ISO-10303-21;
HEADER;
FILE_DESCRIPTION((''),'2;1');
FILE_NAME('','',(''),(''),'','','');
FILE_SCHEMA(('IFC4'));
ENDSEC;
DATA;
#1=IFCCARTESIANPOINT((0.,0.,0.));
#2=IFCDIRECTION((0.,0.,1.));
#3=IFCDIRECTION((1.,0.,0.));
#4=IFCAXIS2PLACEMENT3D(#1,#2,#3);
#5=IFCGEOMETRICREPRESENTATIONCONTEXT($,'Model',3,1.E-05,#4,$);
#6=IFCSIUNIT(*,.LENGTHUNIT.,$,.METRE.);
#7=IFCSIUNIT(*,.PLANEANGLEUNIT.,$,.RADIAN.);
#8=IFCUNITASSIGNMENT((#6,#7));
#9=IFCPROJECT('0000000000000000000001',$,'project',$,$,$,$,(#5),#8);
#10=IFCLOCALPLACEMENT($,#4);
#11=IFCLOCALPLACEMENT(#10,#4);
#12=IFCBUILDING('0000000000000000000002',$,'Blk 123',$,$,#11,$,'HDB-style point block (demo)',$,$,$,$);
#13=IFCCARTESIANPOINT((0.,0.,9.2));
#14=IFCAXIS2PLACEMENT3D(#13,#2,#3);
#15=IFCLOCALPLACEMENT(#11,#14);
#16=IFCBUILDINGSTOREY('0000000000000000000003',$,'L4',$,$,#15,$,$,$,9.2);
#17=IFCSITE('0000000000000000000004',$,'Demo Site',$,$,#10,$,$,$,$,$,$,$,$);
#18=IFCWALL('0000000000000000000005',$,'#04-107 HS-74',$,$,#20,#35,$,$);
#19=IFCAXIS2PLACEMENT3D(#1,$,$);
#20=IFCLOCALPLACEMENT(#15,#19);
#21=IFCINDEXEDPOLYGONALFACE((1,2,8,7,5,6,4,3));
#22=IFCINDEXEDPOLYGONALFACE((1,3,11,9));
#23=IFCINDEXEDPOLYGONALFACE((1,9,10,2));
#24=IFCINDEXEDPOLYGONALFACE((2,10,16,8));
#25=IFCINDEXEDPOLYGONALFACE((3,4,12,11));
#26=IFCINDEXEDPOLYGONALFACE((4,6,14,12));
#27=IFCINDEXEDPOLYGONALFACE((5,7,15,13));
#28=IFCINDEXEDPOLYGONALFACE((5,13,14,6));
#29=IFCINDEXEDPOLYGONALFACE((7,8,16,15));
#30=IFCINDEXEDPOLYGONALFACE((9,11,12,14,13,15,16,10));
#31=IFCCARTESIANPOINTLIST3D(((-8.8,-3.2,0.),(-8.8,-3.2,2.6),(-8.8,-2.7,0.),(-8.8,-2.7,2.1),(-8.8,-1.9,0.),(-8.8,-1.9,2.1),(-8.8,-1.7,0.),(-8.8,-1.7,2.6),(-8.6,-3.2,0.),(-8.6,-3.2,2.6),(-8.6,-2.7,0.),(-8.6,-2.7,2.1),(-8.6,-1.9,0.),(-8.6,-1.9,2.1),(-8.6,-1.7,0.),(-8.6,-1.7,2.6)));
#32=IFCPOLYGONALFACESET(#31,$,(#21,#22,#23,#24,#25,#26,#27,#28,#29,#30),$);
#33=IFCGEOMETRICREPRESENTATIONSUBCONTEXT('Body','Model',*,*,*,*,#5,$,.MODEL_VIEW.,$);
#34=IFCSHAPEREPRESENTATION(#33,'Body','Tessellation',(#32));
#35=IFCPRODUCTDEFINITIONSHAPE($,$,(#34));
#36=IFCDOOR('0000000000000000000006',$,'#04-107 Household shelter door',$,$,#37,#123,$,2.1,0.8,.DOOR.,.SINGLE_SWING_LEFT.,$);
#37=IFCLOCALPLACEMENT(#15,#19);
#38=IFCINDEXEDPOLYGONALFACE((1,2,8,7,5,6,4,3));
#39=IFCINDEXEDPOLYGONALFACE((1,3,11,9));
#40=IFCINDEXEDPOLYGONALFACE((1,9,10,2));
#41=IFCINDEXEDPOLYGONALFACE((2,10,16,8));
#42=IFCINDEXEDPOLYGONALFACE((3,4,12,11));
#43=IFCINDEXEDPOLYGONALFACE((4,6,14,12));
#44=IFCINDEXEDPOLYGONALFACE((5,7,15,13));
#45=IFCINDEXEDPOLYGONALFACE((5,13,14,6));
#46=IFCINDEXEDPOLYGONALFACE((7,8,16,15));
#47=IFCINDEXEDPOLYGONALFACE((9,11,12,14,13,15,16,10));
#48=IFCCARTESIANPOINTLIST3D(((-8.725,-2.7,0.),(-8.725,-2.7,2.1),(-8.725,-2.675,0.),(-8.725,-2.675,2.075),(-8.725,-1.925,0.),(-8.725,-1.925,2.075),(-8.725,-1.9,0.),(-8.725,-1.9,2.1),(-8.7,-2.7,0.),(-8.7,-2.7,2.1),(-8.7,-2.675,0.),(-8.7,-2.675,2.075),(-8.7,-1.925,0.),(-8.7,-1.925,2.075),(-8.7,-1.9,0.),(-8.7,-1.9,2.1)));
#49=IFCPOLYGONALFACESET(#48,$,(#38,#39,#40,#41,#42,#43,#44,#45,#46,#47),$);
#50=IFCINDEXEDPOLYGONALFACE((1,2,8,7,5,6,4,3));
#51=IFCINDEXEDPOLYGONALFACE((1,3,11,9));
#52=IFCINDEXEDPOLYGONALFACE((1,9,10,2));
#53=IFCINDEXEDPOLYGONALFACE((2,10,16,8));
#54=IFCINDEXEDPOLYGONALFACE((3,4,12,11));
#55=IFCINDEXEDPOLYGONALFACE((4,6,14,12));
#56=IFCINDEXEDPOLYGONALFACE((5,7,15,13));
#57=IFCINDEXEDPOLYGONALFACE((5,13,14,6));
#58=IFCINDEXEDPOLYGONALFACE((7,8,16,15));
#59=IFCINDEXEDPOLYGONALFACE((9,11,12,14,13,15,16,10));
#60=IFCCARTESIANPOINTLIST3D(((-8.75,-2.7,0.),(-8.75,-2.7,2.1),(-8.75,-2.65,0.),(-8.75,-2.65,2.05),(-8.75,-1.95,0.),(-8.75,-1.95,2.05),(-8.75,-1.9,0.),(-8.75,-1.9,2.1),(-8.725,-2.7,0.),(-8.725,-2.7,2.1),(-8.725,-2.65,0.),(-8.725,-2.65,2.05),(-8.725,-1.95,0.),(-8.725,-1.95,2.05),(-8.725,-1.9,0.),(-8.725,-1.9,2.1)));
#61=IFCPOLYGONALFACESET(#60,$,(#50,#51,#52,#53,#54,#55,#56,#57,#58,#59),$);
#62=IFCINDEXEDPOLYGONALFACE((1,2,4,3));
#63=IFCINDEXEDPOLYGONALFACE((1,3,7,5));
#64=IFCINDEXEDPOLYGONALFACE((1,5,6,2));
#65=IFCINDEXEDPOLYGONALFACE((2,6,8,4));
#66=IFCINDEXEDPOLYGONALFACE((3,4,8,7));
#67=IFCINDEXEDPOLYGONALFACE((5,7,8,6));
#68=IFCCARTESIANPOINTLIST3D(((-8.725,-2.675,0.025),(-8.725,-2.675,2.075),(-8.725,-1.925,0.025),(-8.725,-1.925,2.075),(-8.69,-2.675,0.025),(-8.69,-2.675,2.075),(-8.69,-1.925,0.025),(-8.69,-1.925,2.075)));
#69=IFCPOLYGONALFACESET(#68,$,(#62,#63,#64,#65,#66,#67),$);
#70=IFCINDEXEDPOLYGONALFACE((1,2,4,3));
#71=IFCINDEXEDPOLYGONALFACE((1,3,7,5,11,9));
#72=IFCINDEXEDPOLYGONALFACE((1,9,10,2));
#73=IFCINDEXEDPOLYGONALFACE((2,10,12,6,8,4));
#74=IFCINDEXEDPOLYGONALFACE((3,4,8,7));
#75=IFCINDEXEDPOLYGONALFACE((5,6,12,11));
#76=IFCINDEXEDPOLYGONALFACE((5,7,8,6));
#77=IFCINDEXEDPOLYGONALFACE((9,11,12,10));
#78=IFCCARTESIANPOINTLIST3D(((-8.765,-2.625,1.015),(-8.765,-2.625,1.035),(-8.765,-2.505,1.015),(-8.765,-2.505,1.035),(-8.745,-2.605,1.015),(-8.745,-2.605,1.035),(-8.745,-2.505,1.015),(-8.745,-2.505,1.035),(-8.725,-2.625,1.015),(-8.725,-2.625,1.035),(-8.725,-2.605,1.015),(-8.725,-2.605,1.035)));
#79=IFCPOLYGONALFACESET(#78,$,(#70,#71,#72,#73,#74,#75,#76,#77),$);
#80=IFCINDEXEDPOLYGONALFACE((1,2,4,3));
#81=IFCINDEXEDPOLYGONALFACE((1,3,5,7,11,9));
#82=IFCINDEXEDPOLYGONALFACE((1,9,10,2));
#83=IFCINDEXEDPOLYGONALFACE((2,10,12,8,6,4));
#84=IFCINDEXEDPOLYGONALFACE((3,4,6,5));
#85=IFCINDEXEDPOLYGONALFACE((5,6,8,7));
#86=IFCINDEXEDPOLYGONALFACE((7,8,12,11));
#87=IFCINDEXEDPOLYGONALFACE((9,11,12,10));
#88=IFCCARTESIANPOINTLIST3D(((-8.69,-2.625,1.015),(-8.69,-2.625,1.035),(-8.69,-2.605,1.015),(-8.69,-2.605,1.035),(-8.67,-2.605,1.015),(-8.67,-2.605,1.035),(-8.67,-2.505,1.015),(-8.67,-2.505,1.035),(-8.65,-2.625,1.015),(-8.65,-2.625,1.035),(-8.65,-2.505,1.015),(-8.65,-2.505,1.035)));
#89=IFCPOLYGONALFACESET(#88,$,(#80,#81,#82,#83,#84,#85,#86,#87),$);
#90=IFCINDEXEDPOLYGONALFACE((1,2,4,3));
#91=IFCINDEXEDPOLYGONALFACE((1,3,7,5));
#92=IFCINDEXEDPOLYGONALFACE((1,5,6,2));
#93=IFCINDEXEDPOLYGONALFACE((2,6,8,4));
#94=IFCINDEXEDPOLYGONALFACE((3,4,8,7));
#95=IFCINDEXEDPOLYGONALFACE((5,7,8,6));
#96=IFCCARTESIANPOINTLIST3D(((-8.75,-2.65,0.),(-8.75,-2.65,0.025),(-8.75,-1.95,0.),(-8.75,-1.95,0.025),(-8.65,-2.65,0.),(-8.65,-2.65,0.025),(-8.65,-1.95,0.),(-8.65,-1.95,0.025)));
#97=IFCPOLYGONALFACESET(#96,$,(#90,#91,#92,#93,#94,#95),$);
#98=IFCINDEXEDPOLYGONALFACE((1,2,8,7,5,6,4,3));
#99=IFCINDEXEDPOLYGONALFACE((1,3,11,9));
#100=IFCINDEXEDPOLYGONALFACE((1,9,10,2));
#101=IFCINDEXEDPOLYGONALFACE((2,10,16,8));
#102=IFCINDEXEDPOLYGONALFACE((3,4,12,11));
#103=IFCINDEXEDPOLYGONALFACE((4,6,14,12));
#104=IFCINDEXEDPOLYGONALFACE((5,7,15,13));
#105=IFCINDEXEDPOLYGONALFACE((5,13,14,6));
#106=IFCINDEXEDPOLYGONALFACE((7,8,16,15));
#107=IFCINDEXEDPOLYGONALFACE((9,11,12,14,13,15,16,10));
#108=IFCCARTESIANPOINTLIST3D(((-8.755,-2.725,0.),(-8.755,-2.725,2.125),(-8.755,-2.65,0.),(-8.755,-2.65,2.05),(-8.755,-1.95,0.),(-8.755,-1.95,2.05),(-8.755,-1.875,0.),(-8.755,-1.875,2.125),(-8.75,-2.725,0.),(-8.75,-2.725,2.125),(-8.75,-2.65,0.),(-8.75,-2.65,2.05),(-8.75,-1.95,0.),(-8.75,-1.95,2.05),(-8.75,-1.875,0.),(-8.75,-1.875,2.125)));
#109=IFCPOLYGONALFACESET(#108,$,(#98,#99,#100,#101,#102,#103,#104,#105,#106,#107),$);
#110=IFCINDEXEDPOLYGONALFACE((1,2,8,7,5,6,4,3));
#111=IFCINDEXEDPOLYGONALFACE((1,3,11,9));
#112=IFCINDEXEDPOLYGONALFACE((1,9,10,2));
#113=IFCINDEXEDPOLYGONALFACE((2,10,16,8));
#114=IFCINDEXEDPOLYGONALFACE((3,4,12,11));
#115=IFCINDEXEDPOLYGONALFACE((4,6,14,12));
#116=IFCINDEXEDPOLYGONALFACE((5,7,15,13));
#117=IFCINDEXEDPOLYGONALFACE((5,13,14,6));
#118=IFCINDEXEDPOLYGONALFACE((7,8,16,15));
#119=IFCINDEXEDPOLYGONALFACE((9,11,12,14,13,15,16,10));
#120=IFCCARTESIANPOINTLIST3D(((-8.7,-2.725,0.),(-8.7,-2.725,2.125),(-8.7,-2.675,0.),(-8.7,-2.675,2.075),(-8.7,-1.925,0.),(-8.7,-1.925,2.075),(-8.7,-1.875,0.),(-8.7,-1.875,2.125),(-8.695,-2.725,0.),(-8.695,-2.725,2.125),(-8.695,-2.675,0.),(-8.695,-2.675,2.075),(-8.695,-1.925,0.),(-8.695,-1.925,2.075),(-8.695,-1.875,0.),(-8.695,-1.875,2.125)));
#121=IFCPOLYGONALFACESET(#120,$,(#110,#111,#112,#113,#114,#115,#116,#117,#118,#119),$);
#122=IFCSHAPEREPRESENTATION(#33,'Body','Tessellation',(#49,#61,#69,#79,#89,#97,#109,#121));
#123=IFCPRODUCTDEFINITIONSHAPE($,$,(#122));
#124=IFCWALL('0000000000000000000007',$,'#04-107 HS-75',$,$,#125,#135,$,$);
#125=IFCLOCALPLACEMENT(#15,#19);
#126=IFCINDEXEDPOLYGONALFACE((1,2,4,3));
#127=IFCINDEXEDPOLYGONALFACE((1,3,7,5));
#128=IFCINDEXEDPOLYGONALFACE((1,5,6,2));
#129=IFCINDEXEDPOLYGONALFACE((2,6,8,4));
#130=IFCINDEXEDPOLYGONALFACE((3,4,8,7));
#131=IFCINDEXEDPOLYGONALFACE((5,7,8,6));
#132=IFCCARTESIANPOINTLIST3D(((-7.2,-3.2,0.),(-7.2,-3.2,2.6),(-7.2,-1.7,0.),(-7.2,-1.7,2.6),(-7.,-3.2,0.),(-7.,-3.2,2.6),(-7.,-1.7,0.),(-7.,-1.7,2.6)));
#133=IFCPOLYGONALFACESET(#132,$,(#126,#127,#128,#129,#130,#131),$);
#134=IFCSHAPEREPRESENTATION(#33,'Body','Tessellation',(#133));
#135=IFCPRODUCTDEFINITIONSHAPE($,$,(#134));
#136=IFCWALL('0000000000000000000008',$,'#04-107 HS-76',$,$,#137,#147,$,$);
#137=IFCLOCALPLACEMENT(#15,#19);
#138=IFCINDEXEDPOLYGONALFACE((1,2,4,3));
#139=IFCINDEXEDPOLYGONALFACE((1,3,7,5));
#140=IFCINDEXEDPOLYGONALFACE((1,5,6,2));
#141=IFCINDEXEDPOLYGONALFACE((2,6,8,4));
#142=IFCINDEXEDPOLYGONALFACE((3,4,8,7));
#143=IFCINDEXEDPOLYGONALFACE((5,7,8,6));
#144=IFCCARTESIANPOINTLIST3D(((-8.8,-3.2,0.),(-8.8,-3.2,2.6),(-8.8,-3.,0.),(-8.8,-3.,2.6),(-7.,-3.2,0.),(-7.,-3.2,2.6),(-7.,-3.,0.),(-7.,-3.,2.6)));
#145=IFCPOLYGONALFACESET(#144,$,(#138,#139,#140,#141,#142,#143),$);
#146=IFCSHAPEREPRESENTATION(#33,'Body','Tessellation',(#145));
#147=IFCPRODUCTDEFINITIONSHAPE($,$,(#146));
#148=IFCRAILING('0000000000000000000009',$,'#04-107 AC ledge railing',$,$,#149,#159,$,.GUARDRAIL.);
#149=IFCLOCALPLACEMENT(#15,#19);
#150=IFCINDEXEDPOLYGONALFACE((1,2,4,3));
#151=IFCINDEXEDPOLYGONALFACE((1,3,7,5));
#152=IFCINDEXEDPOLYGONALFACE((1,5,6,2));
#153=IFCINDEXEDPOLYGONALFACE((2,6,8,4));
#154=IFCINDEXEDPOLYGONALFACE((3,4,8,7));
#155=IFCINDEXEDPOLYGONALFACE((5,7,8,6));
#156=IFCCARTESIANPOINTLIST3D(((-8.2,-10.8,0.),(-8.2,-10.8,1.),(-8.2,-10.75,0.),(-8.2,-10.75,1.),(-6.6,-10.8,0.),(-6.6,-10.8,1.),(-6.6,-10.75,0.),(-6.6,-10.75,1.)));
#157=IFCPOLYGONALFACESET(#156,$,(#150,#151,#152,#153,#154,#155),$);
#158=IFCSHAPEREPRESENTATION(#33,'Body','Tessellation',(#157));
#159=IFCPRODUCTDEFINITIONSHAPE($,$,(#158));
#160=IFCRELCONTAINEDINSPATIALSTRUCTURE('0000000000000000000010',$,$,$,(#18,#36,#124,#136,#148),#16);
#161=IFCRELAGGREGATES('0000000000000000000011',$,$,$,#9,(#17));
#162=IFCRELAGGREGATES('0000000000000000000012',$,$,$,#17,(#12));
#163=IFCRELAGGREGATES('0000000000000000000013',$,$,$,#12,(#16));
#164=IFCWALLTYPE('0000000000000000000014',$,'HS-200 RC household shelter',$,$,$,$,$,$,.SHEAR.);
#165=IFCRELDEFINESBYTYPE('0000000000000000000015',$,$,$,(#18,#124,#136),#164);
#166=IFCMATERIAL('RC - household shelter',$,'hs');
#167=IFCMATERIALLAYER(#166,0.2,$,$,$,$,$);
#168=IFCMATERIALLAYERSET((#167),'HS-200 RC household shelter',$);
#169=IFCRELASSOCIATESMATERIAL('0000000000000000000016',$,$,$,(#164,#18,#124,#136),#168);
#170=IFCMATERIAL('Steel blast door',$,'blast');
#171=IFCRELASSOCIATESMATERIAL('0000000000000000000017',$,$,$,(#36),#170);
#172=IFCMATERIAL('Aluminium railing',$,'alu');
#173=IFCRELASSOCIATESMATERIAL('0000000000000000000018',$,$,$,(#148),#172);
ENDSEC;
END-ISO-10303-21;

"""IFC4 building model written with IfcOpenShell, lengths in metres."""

from ifc_helpers import new_model, si_unit, frame, origin, origin_with_axes, place, context, subcontext, project, spatial, polyline, line, indexed_curve, outline, extrude, material, layer, layer_set, layer_usage, type_object, element, fill, save


model = new_model("IFC4")

# Units and contexts
model_context = context("Model", 3, precision=1e-05, world=origin_with_axes())
body_context = subcontext(model_context, "Body", "Model", "MODEL_VIEW")
ifc_project = project(units=[si_unit("LENGTHUNIT", "METRE"), si_unit("PLANEANGLEUNIT", "RADIAN")], contexts=[model_context])

# Site, building, storey
site_placement = place(None, origin_with_axes())
site = spatial("IfcSite", under=ifc_project, at=site_placement, Name="Demo Site")
building_placement = place(site_placement, origin_with_axes())
building = spatial("IfcBuilding", under=site, at=building_placement, Name="Blk 123", LongName="HDB-style point block (demo)")
storey_placement = place(building_placement, frame((0.0, 0.0, 9.2), z_axis=(0.0, 0.0, 1.0), x_axis=(1.0, 0.0, 0.0)))
storey = spatial("IfcBuildingStorey", under=building, at=storey_placement, Name="L4", Elevation=9.2)

# Wall, opening, door
ifc_material_1 = material(Name="RC - household shelter", Category="hs")
ifc_layer_1 = layer(ifc_material_1, 0.2)
ifc_layer_set_1 = layer_set([ifc_layer_1], Name="HS-200 RC household shelter")
ifc_layer_usage_1 = layer_usage(ifc_layer_set_1, "AXIS2", "POSITIVE", -0.1)
wall_type_1 = type_object("IfcWallType", Name="HS-200 RC household shelter", PredefinedType="SHEAR", material=ifc_layer_set_1)
wall_1_placement = place(storey_placement, frame((-8.7, -1.7, 0.0), z_axis=(0.0, 0.0, 1.0), x_axis=(0.0, -1.0, 0.0)))
wall_1 = element("IfcWall", 1, at=wall_1_placement, inside=storey, type_object=wall_type_1, material=ifc_layer_usage_1, Name="#04-107 HS-74", context=body_context, shape_type="SweptSolid", body=[
    extrude(outline(indexed_curve([(0.0, 0.0), (0.0, 0.2), (1.5, 0.2), (1.5, 0.0), (0.0, 0.0)], self_intersect=False)), frame((0.0, -0.1, 0.0), z_axis=(0.0, 0.0, 1.0), x_axis=(1.0, 0.0, 0.0)), (0.0, 0.0, 1.0), 2.6),
])
opening_1_placement = place(wall_1_placement, frame((0.2, -0.2, 0.0), z_axis=(0.0, 0.0, 1.0), x_axis=(1.0, 0.0, 0.0)))
opening_1 = element("IfcOpeningElement", 2, at=opening_1_placement, cuts=wall_1, context=body_context, shape_type="SweptSolid", body=[
    extrude(outline(indexed_curve([(0.0, 0.0), (0.0, 0.4), (0.8, 0.4), (0.8, 0.0), (0.0, 0.0)], self_intersect=False)), origin_with_axes(), (0.0, 0.0, 1.0), 2.1),
])
ifc_material_2 = material(Name="Steel blast door", Category="blast")
door_1_placement = place(opening_1_placement, frame((0.0, 0.15, 0.0), z_axis=(0.0, 0.0, 1.0), x_axis=(1.0, 0.0, 0.0)))
door_1 = element("IfcDoor", 3, at=door_1_placement, inside=storey, material=ifc_material_2, Name="#04-107 Household shelter door", OperationType="SINGLE_SWING_LEFT", OverallHeight=2.1, OverallWidth=0.8, PredefinedType="DOOR", context=body_context, shape_type="SweptSolid", body=[
    extrude(outline(indexed_curve([(0.0, 0.0), (0.0, 2.1), (0.8, 2.1), (0.8, 0.0), (0.775, 0.0), (0.775, 2.075), (0.025, 2.075), (0.025, 0.0)], segments=[line(1, 2, 3, 4, 5, 6, 7, 8, 1)])), frame((0.0, 0.025, 0.0), z_axis=(0.0, -1.0, 0.0), x_axis=(1.0, 0.0, 0.0)), (0.0, 0.0, -1.0), 0.025),
    extrude(outline(indexed_curve([(0.0, 0.0), (0.0, 2.1), (0.8, 2.1), (0.8, 0.0), (0.75, 0.0), (0.75, 2.05), (0.05, 2.05), (0.05, 0.0)], segments=[line(1, 2, 3, 4, 5, 6, 7, 8, 1)])), frame((0.0, 0.0, 0.0), z_axis=(0.0, -1.0, 0.0), x_axis=(1.0, 0.0, 0.0)), (0.0, 0.0, -1.0), 0.025),
    extrude(outline(indexed_curve([(0.0, 0.0), (0.75, 0.0), (0.75, 0.035), (0.0, 0.035)], segments=[line(1, 2, 3, 4, 1)])), frame((0.025, 0.025, 0.025), z_axis=(0.0, 0.0, 1.0), x_axis=(1.0, 0.0, 0.0)), (0.0, 0.0, 1.0), 2.05),
    extrude(outline(indexed_curve([(0.0, 0.0), (0.0, -0.04), (-0.12, -0.04), (-0.12, -0.02), (-0.02, -0.02), (-0.02, 0.0)], segments=[line(1, 2, 3, 4, 5, 6, 1)])), frame((0.725, 0.025, 1.015), z_axis=(0.0, 0.0, 1.0), x_axis=(1.0, 0.0, 0.0)), (0.0, 0.0, 1.0), 0.02),
    extrude(outline(indexed_curve([(0.0, 0.0), (0.0, 0.04), (-0.12, 0.04), (-0.12, 0.02), (-0.02, 0.02), (-0.02, 0.0)], segments=[line(1, 2, 3, 4, 5, 6, 1)])), frame((0.725, 0.06, 1.015), z_axis=(0.0, 0.0, 1.0), x_axis=(1.0, 0.0, 0.0)), (0.0, 0.0, 1.0), 0.02),
    extrude(outline(indexed_curve([(0.0, 0.0), (0.7, 0.0), (0.7, 0.1), (0.0, 0.1)], segments=[line(1, 2, 3, 4, 1)])), frame((0.05, 0.0, 0.0), z_axis=(0.0, 0.0, 1.0), x_axis=(1.0, 0.0, 0.0)), (0.0, 0.0, 1.0), 0.025),
    extrude(outline(indexed_curve([(0.0, 0.0), (0.0, 2.125), (0.85, 2.125), (0.85, 0.0), (0.775, 0.0), (0.775, 2.05), (0.075, 2.05), (0.075, 0.0)], segments=[line(1, 2, 3, 4, 5, 6, 7, 8, 1)])), frame((-0.025, -0.005, 0.0), z_axis=(0.0, -1.0, 0.0), x_axis=(1.0, 0.0, 0.0)), (0.0, 0.0, -1.0), 0.005),
    extrude(outline(indexed_curve([(0.0, 0.0), (0.0, 2.125), (0.85, 2.125), (0.85, 0.0), (0.8, 0.0), (0.8, 2.075), (0.05, 2.075), (0.05, 0.0)], segments=[line(1, 2, 3, 4, 5, 6, 7, 8, 1)])), frame((-0.025, 0.05, 0.0), z_axis=(0.0, -1.0, 0.0), x_axis=(1.0, 0.0, 0.0)), (0.0, 0.0, -1.0), 0.005),
])
fill(opening_1, door_1)

# Walls
wall_2_placement = place(storey_placement, frame((-7.1, -1.7, 0.0), z_axis=(0.0, 0.0, 1.0), x_axis=(0.0, -1.0, 0.0)))
element("IfcWall", 4, at=wall_2_placement, inside=storey, type_object=wall_type_1, material=ifc_layer_usage_1, Name="#04-107 HS-75", context=body_context, shape_type="SweptSolid", body=[
    extrude(outline(indexed_curve([(0.0, 0.0), (0.0, 0.2), (1.5, 0.2), (1.5, 0.0), (0.0, 0.0)], self_intersect=False)), frame((0.0, -0.1, 0.0), z_axis=(0.0, 0.0, 1.0), x_axis=(1.0, 0.0, 0.0)), (0.0, 0.0, 1.0), 2.6),
])
wall_3_placement = place(storey_placement, frame((-7.0, -3.1, 0.0), z_axis=(0.0, 0.0, 1.0), x_axis=(-1.0, 0.0, 0.0)))
element("IfcWall", 5, at=wall_3_placement, inside=storey, type_object=wall_type_1, material=ifc_layer_usage_1, Name="#04-107 HS-76", context=body_context, shape_type="SweptSolid", body=[
    extrude(outline(indexed_curve([(0.0, 0.0), (0.0, 0.2), (1.8, 0.2), (1.8, 0.0), (0.0, 0.0)], self_intersect=False)), frame((0.0, -0.1, 0.0), z_axis=(0.0, 0.0, 1.0), x_axis=(1.0, 0.0, 0.0)), (0.0, 0.0, 1.0), 2.6),
])

# Railing
ifc_material_3 = material(Name="Aluminium railing", Category="alu")
railing_placement = place(storey_placement, frame((-7.4, -10.775, 0.0), z_axis=(0.0, 0.0, 1.0), x_axis=(1.0, 0.0, 0.0)))
element("IfcRailing", 6, at=railing_placement, inside=storey, material=ifc_material_3, Name="#04-107 AC ledge railing", PredefinedType="GUARDRAIL", context=body_context, shape_type="SweptSolid", body=[
    extrude(outline(polyline([(-0.8, 0.025), (-0.8, -0.025), (0.8, -0.025), (0.8, 0.025), (-0.8, 0.025)])), origin(), (0.0, 0.0, 1.0), 1.0),
])

save(model, "model.ifc")
